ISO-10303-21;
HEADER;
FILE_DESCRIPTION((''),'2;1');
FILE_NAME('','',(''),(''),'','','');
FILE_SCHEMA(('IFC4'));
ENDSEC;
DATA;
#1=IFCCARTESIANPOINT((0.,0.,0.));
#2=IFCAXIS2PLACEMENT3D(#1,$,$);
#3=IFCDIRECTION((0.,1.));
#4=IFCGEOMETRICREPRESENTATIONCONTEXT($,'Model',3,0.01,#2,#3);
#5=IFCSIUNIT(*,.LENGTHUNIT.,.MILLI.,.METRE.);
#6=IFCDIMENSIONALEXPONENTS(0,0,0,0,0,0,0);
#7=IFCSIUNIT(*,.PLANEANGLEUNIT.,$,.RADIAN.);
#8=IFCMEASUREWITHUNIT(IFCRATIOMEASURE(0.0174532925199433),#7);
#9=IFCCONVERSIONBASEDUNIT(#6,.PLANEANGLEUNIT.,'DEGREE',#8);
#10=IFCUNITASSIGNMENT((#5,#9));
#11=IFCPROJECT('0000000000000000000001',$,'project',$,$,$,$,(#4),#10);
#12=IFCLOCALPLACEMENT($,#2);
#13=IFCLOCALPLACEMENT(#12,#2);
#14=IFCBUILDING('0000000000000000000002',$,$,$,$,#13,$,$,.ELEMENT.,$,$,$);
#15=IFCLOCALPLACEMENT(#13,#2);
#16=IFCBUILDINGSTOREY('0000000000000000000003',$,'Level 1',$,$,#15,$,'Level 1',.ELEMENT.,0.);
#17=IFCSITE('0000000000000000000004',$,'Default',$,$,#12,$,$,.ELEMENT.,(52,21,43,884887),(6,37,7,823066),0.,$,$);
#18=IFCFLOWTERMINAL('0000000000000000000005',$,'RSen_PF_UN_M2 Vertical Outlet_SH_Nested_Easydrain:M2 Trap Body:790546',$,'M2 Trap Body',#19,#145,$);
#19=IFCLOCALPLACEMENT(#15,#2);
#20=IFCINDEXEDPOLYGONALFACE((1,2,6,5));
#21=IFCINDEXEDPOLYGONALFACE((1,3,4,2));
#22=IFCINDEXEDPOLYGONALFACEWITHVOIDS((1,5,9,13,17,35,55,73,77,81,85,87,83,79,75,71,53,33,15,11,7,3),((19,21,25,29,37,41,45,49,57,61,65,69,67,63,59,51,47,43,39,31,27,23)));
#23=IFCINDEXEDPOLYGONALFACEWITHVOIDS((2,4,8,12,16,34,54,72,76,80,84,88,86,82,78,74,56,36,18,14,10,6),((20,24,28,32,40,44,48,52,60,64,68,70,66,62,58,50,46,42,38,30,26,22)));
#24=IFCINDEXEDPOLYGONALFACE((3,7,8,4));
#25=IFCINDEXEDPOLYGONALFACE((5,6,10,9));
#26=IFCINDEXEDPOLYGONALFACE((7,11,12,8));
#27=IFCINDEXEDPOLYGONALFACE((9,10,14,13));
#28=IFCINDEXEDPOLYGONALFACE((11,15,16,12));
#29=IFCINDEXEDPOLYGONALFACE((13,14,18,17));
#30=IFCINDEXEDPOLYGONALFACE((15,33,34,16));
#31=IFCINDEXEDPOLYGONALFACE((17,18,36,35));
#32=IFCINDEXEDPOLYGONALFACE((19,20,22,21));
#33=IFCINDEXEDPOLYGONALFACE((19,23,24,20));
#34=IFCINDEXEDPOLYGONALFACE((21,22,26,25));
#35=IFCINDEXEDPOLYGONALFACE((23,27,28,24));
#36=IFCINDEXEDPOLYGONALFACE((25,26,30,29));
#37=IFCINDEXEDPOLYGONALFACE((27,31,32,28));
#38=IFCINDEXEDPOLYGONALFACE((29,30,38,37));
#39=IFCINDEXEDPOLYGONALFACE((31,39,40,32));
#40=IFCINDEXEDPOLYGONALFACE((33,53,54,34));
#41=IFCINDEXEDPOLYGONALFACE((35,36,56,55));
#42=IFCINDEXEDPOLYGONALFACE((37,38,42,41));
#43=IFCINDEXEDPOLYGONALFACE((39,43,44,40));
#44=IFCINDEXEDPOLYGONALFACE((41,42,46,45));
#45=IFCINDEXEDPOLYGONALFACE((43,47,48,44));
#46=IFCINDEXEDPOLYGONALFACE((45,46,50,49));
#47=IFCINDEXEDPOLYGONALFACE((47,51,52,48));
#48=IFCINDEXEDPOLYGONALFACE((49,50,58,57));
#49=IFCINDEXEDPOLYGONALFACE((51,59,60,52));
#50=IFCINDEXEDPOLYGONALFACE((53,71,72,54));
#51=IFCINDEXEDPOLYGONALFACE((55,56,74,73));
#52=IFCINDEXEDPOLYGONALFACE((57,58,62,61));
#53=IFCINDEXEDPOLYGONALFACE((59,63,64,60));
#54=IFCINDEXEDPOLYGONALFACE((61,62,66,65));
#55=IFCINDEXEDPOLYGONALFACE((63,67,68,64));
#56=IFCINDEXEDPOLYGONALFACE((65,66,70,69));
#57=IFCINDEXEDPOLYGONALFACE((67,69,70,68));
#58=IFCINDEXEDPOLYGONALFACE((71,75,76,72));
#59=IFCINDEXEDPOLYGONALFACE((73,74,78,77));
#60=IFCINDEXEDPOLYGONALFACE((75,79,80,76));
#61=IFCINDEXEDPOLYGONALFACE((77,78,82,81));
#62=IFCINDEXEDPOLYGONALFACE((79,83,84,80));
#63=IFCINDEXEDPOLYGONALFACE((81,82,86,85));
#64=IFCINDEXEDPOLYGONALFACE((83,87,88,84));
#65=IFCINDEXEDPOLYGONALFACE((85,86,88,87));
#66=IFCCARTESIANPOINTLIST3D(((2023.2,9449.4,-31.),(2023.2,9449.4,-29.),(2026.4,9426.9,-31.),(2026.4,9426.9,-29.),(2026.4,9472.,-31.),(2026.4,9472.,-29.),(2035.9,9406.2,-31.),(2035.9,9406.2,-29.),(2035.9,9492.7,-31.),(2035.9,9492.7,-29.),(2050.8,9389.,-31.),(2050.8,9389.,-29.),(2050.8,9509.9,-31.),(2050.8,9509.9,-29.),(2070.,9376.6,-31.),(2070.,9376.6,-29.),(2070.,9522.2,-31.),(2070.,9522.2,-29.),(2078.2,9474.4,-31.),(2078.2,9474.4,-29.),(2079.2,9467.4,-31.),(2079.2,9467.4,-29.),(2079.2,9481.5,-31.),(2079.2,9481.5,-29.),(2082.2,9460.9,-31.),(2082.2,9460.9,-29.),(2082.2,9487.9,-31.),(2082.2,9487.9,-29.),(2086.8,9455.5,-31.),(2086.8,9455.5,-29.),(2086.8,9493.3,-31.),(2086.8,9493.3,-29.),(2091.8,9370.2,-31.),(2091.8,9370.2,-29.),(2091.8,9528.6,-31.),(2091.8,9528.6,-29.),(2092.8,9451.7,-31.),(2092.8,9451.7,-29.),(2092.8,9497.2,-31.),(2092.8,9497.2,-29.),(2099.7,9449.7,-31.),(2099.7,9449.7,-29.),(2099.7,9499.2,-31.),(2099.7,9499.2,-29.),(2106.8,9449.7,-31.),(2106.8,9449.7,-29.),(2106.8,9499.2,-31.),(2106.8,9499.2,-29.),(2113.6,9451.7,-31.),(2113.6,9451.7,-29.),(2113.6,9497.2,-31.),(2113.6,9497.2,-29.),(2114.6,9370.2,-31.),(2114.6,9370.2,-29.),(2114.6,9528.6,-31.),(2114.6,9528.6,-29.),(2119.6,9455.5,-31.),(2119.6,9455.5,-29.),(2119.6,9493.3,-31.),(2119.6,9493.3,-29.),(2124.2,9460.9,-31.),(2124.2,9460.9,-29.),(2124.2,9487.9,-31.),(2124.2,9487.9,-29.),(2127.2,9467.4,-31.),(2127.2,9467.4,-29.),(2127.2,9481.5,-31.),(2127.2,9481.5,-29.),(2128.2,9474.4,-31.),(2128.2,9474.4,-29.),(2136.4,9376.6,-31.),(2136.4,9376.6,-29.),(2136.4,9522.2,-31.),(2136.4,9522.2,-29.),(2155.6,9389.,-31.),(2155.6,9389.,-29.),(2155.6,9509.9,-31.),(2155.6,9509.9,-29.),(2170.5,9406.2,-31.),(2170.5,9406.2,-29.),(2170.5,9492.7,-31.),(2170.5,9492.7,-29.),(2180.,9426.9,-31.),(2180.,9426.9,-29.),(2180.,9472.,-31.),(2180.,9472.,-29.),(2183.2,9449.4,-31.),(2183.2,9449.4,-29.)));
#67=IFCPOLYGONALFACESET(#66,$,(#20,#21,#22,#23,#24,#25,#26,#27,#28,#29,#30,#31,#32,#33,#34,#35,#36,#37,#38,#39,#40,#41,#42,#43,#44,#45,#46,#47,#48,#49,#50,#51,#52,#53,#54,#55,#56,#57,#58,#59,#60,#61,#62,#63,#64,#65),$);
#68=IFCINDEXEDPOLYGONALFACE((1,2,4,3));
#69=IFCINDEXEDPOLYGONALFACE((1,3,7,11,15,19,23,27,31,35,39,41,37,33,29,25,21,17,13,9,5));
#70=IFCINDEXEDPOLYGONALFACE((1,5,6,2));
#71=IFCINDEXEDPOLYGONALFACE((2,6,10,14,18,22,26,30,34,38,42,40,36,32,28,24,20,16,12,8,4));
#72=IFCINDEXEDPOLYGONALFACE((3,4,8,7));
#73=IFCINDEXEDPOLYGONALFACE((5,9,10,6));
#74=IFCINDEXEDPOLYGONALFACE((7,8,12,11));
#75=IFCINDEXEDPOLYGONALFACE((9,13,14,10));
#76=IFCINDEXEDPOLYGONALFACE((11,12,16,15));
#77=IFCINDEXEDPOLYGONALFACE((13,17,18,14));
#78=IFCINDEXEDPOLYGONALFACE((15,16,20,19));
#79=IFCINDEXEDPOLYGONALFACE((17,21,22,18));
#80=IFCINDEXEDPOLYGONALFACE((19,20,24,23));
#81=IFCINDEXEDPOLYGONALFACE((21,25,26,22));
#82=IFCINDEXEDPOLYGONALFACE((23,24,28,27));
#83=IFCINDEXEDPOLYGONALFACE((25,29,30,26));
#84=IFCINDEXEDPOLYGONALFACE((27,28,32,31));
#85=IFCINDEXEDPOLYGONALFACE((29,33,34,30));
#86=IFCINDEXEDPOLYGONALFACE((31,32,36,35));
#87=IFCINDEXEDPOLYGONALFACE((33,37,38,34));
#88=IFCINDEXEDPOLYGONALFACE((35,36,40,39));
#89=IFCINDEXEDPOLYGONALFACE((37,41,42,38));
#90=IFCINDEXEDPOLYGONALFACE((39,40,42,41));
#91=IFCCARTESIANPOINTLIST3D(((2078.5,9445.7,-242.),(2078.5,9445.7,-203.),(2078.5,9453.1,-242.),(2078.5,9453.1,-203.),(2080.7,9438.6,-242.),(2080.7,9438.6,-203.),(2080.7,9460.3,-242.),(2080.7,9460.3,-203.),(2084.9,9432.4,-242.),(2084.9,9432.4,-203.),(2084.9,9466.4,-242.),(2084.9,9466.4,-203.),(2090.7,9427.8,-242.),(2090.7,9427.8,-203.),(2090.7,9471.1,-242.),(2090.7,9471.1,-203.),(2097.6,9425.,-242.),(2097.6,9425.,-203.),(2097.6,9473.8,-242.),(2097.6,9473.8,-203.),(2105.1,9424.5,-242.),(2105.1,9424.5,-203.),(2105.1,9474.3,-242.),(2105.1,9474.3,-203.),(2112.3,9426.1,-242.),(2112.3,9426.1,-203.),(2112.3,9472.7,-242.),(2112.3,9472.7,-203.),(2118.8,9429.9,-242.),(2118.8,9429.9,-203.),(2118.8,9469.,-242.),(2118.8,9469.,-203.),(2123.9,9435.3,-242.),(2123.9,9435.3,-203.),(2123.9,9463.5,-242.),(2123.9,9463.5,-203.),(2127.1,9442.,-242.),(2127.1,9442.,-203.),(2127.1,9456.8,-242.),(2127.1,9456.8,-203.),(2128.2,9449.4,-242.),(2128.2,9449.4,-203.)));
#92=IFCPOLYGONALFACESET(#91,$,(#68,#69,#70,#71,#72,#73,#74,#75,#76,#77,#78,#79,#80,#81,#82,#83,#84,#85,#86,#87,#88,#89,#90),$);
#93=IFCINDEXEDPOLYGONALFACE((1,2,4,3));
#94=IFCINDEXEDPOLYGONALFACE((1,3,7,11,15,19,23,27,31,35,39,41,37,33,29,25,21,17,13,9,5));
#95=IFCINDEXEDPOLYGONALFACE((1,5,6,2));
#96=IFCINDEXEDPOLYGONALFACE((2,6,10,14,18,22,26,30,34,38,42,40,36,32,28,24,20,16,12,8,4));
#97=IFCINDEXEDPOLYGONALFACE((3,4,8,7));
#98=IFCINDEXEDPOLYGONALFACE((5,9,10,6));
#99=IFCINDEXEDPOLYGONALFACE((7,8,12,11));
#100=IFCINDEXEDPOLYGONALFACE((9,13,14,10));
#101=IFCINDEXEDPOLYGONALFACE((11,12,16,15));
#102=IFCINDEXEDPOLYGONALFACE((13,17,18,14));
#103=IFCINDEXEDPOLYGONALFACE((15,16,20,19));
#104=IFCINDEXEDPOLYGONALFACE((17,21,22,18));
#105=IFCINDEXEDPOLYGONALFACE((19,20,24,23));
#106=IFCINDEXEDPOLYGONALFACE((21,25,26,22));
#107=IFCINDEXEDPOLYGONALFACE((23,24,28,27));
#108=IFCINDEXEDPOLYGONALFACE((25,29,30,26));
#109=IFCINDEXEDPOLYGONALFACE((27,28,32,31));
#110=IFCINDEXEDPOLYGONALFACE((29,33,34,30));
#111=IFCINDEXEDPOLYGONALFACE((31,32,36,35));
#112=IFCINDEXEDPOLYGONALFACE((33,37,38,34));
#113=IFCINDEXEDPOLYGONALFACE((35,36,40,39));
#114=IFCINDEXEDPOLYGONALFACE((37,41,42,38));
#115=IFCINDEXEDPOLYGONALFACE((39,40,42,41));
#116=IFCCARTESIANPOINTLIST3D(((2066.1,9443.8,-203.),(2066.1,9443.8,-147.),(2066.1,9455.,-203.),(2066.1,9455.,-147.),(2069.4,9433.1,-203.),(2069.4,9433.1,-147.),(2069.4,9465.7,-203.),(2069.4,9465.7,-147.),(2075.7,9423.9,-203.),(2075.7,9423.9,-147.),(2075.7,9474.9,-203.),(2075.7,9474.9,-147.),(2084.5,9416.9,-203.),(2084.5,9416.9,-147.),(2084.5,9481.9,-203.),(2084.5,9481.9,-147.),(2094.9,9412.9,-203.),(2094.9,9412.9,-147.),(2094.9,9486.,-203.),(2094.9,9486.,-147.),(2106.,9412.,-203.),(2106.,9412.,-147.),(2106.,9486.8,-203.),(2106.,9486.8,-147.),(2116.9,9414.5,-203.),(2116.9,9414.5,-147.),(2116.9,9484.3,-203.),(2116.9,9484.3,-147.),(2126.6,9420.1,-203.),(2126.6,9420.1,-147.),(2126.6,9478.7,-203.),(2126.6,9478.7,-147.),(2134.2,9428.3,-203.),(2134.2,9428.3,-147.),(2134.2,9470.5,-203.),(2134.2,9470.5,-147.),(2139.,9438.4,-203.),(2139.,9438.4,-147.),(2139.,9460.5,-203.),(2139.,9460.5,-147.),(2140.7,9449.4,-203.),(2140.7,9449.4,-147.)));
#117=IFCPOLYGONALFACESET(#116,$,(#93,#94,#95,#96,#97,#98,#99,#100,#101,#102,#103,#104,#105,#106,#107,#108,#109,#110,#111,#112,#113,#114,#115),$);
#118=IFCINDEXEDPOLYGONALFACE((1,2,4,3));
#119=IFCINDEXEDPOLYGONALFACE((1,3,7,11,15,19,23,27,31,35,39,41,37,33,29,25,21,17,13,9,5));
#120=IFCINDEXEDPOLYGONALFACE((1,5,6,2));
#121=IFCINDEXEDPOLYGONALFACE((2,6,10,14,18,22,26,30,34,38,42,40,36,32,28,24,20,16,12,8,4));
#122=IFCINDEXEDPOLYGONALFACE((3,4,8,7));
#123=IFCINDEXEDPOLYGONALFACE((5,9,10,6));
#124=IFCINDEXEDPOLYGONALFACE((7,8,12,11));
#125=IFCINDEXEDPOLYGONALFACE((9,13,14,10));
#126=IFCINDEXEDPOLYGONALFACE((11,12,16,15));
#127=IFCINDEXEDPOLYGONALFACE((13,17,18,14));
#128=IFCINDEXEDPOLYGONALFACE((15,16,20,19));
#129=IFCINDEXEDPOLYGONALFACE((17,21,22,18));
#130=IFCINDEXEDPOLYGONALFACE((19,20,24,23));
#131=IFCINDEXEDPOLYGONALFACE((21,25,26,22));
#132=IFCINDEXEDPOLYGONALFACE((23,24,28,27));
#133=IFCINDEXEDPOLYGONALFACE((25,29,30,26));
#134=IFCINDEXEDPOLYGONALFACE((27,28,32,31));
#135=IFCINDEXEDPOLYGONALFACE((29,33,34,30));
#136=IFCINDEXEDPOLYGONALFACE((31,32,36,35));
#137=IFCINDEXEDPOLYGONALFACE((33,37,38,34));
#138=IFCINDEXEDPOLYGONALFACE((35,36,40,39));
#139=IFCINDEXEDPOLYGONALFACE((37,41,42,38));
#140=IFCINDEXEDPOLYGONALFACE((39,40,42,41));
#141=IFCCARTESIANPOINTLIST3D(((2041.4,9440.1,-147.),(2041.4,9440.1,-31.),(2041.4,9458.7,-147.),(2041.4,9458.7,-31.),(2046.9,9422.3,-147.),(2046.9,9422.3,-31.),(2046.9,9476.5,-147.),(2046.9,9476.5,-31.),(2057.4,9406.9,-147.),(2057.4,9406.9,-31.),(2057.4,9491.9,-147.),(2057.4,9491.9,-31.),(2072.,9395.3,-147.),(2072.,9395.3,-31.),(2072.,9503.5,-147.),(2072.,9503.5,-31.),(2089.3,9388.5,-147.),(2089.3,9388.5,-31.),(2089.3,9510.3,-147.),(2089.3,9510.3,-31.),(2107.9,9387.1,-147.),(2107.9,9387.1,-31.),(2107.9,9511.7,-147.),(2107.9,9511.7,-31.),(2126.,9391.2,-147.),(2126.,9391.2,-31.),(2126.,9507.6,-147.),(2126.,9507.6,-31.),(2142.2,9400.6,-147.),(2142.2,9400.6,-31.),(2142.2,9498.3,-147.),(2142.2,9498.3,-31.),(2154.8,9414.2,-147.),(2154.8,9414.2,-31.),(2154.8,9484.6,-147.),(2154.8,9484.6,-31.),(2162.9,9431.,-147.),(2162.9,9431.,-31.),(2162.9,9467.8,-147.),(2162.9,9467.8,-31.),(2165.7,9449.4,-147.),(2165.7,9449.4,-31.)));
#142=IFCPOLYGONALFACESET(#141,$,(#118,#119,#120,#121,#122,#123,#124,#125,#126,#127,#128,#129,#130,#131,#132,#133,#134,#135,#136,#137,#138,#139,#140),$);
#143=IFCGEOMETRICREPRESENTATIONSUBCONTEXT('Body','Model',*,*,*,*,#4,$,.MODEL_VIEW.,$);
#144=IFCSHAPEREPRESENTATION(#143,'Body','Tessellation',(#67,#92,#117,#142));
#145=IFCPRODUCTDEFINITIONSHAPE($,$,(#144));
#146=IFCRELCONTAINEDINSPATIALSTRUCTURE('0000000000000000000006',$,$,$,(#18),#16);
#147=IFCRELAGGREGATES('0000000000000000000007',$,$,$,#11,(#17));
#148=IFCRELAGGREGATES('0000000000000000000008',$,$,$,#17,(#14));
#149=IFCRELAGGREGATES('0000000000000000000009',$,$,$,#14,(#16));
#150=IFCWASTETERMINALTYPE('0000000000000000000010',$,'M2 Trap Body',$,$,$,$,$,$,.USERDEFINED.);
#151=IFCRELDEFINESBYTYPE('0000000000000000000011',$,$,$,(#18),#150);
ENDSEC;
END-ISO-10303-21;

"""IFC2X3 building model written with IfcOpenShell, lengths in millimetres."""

from ifc_helpers import new_model, entity, si_unit, converted_unit, direction, frame, frame_2d, origin, origin_2d_with_axis, place, context, subcontext, project, spatial, circle_curve, parameter, trimmed, segment, composite_curve, circle, outline, extrude, source, transform, mapped, type_object, type_shapes, element, save


model = new_model("IFC2X3")

# Units and contexts
model_context = context("Model", 3, precision=0.01, world=origin(), true_north=direction((0.0, 1.0)))
body_context = subcontext(model_context, "Body", "Model", "MODEL_VIEW")
ifc_project = project(units=[si_unit("LENGTHUNIT", "METRE", prefix="MILLI"), converted_unit("PLANEANGLEUNIT", "DEGREE", entity("IfcRatioMeasure", 0.0174532925199433), si_unit("PLANEANGLEUNIT", "RADIAN"), dimensions=[0, 0, 0, 0, 0, 0, 0])], contexts=[model_context])

# Site, building, storey
site_placement = place(None, origin())
site = spatial("IfcSite", under=ifc_project, at=site_placement, Name="Default", CompositionType="ELEMENT", RefLatitude=(52, 21, 43, 884887), RefLongitude=(6, 37, 7, 823066), RefElevation=0.0)
building_placement = place(site_placement, origin())
building = spatial("IfcBuilding", under=site, at=building_placement, CompositionType="ELEMENT")
storey_placement = place(building_placement, origin())
storey = spatial("IfcBuildingStorey", under=building, at=storey_placement, Name="Level 1", LongName="Level 1", CompositionType="ELEMENT", Elevation=0.0)

# Flow terminal
waste_terminal_type_1 = type_object("IfcWasteTerminalType", Name="M2 Trap Body", PredefinedType="USERDEFINED")
shared_shape_1 = source(origin(), body_context, "Body", "SweptSolid", [
    extrude(outline(composite_curve([segment(trimmed(circle_curve(origin_2d_with_axis(), 80.0), [parameter(0.0)], [parameter(180.0)], True, "PARAMETER"), True, "CONTINUOUS"), segment(trimmed(circle_curve(origin_2d_with_axis(), 80.0), [parameter(180.0)], [parameter(360.0)], True, "PARAMETER"), True, "CONTINUOUS")], self_intersect=False), holes=[composite_curve([segment(trimmed(circle_curve(frame_2d((0.0, 25.0), x_axis=(1.0, 0.0)), 25.0), [parameter(180.0)], [parameter(360.0)], True, "PARAMETER"), False, "CONTINUOUS"), segment(trimmed(circle_curve(frame_2d((0.0, 25.0), x_axis=(1.0, 0.0)), 25.0), [parameter(0.0)], [parameter(180.0)], True, "PARAMETER"), False, "CONTINUOUS")], self_intersect=False)]), frame((0.0, -25.0, -2.0)), (0.0, 0.0, 1.0), 2.0),
    extrude(circle(Radius=25.0, at=frame_2d((0.0, 0.0), x_axis=(1.0, 0.0))), frame((0.0, -25.0, -213.0)), (0.0, 0.0, 1.0), 39.0),
    extrude(circle(Radius=37.5, at=frame_2d((0.0, 0.0), x_axis=(1.0, 0.0))), frame((0.0, -25.0, -174.0)), (0.0, 0.0, 1.0), 56.0),
    extrude(circle(Radius=62.5, at=frame_2d((0.0, 0.0), x_axis=(1.0, 0.0))), frame((0.0, -25.0, -118.0)), (0.0, 0.0, 1.0), 116.0),
])
type_shapes(waste_terminal_type_1, [shared_shape_1])
for number, where, name in (
    (1, (2103.2, 9474.4, -29.0), "RSen_PF_UN_M2 Vertical Outlet_SH_Nested_Easydrain:M2 Trap Body:790546"),
):
    element("IfcFlowTerminal", number, at=place(storey_placement, frame(where)), inside=storey, type_object=waste_terminal_type_1, Name=name, ObjectType="M2 Trap Body", context=body_context, shape_type="MappedRepresentation", body=[
        mapped(shared_shape_1, transform((0.0, 0.0, 0.0), scale=1.0)),
    ])

save(model, "model.ifc")
